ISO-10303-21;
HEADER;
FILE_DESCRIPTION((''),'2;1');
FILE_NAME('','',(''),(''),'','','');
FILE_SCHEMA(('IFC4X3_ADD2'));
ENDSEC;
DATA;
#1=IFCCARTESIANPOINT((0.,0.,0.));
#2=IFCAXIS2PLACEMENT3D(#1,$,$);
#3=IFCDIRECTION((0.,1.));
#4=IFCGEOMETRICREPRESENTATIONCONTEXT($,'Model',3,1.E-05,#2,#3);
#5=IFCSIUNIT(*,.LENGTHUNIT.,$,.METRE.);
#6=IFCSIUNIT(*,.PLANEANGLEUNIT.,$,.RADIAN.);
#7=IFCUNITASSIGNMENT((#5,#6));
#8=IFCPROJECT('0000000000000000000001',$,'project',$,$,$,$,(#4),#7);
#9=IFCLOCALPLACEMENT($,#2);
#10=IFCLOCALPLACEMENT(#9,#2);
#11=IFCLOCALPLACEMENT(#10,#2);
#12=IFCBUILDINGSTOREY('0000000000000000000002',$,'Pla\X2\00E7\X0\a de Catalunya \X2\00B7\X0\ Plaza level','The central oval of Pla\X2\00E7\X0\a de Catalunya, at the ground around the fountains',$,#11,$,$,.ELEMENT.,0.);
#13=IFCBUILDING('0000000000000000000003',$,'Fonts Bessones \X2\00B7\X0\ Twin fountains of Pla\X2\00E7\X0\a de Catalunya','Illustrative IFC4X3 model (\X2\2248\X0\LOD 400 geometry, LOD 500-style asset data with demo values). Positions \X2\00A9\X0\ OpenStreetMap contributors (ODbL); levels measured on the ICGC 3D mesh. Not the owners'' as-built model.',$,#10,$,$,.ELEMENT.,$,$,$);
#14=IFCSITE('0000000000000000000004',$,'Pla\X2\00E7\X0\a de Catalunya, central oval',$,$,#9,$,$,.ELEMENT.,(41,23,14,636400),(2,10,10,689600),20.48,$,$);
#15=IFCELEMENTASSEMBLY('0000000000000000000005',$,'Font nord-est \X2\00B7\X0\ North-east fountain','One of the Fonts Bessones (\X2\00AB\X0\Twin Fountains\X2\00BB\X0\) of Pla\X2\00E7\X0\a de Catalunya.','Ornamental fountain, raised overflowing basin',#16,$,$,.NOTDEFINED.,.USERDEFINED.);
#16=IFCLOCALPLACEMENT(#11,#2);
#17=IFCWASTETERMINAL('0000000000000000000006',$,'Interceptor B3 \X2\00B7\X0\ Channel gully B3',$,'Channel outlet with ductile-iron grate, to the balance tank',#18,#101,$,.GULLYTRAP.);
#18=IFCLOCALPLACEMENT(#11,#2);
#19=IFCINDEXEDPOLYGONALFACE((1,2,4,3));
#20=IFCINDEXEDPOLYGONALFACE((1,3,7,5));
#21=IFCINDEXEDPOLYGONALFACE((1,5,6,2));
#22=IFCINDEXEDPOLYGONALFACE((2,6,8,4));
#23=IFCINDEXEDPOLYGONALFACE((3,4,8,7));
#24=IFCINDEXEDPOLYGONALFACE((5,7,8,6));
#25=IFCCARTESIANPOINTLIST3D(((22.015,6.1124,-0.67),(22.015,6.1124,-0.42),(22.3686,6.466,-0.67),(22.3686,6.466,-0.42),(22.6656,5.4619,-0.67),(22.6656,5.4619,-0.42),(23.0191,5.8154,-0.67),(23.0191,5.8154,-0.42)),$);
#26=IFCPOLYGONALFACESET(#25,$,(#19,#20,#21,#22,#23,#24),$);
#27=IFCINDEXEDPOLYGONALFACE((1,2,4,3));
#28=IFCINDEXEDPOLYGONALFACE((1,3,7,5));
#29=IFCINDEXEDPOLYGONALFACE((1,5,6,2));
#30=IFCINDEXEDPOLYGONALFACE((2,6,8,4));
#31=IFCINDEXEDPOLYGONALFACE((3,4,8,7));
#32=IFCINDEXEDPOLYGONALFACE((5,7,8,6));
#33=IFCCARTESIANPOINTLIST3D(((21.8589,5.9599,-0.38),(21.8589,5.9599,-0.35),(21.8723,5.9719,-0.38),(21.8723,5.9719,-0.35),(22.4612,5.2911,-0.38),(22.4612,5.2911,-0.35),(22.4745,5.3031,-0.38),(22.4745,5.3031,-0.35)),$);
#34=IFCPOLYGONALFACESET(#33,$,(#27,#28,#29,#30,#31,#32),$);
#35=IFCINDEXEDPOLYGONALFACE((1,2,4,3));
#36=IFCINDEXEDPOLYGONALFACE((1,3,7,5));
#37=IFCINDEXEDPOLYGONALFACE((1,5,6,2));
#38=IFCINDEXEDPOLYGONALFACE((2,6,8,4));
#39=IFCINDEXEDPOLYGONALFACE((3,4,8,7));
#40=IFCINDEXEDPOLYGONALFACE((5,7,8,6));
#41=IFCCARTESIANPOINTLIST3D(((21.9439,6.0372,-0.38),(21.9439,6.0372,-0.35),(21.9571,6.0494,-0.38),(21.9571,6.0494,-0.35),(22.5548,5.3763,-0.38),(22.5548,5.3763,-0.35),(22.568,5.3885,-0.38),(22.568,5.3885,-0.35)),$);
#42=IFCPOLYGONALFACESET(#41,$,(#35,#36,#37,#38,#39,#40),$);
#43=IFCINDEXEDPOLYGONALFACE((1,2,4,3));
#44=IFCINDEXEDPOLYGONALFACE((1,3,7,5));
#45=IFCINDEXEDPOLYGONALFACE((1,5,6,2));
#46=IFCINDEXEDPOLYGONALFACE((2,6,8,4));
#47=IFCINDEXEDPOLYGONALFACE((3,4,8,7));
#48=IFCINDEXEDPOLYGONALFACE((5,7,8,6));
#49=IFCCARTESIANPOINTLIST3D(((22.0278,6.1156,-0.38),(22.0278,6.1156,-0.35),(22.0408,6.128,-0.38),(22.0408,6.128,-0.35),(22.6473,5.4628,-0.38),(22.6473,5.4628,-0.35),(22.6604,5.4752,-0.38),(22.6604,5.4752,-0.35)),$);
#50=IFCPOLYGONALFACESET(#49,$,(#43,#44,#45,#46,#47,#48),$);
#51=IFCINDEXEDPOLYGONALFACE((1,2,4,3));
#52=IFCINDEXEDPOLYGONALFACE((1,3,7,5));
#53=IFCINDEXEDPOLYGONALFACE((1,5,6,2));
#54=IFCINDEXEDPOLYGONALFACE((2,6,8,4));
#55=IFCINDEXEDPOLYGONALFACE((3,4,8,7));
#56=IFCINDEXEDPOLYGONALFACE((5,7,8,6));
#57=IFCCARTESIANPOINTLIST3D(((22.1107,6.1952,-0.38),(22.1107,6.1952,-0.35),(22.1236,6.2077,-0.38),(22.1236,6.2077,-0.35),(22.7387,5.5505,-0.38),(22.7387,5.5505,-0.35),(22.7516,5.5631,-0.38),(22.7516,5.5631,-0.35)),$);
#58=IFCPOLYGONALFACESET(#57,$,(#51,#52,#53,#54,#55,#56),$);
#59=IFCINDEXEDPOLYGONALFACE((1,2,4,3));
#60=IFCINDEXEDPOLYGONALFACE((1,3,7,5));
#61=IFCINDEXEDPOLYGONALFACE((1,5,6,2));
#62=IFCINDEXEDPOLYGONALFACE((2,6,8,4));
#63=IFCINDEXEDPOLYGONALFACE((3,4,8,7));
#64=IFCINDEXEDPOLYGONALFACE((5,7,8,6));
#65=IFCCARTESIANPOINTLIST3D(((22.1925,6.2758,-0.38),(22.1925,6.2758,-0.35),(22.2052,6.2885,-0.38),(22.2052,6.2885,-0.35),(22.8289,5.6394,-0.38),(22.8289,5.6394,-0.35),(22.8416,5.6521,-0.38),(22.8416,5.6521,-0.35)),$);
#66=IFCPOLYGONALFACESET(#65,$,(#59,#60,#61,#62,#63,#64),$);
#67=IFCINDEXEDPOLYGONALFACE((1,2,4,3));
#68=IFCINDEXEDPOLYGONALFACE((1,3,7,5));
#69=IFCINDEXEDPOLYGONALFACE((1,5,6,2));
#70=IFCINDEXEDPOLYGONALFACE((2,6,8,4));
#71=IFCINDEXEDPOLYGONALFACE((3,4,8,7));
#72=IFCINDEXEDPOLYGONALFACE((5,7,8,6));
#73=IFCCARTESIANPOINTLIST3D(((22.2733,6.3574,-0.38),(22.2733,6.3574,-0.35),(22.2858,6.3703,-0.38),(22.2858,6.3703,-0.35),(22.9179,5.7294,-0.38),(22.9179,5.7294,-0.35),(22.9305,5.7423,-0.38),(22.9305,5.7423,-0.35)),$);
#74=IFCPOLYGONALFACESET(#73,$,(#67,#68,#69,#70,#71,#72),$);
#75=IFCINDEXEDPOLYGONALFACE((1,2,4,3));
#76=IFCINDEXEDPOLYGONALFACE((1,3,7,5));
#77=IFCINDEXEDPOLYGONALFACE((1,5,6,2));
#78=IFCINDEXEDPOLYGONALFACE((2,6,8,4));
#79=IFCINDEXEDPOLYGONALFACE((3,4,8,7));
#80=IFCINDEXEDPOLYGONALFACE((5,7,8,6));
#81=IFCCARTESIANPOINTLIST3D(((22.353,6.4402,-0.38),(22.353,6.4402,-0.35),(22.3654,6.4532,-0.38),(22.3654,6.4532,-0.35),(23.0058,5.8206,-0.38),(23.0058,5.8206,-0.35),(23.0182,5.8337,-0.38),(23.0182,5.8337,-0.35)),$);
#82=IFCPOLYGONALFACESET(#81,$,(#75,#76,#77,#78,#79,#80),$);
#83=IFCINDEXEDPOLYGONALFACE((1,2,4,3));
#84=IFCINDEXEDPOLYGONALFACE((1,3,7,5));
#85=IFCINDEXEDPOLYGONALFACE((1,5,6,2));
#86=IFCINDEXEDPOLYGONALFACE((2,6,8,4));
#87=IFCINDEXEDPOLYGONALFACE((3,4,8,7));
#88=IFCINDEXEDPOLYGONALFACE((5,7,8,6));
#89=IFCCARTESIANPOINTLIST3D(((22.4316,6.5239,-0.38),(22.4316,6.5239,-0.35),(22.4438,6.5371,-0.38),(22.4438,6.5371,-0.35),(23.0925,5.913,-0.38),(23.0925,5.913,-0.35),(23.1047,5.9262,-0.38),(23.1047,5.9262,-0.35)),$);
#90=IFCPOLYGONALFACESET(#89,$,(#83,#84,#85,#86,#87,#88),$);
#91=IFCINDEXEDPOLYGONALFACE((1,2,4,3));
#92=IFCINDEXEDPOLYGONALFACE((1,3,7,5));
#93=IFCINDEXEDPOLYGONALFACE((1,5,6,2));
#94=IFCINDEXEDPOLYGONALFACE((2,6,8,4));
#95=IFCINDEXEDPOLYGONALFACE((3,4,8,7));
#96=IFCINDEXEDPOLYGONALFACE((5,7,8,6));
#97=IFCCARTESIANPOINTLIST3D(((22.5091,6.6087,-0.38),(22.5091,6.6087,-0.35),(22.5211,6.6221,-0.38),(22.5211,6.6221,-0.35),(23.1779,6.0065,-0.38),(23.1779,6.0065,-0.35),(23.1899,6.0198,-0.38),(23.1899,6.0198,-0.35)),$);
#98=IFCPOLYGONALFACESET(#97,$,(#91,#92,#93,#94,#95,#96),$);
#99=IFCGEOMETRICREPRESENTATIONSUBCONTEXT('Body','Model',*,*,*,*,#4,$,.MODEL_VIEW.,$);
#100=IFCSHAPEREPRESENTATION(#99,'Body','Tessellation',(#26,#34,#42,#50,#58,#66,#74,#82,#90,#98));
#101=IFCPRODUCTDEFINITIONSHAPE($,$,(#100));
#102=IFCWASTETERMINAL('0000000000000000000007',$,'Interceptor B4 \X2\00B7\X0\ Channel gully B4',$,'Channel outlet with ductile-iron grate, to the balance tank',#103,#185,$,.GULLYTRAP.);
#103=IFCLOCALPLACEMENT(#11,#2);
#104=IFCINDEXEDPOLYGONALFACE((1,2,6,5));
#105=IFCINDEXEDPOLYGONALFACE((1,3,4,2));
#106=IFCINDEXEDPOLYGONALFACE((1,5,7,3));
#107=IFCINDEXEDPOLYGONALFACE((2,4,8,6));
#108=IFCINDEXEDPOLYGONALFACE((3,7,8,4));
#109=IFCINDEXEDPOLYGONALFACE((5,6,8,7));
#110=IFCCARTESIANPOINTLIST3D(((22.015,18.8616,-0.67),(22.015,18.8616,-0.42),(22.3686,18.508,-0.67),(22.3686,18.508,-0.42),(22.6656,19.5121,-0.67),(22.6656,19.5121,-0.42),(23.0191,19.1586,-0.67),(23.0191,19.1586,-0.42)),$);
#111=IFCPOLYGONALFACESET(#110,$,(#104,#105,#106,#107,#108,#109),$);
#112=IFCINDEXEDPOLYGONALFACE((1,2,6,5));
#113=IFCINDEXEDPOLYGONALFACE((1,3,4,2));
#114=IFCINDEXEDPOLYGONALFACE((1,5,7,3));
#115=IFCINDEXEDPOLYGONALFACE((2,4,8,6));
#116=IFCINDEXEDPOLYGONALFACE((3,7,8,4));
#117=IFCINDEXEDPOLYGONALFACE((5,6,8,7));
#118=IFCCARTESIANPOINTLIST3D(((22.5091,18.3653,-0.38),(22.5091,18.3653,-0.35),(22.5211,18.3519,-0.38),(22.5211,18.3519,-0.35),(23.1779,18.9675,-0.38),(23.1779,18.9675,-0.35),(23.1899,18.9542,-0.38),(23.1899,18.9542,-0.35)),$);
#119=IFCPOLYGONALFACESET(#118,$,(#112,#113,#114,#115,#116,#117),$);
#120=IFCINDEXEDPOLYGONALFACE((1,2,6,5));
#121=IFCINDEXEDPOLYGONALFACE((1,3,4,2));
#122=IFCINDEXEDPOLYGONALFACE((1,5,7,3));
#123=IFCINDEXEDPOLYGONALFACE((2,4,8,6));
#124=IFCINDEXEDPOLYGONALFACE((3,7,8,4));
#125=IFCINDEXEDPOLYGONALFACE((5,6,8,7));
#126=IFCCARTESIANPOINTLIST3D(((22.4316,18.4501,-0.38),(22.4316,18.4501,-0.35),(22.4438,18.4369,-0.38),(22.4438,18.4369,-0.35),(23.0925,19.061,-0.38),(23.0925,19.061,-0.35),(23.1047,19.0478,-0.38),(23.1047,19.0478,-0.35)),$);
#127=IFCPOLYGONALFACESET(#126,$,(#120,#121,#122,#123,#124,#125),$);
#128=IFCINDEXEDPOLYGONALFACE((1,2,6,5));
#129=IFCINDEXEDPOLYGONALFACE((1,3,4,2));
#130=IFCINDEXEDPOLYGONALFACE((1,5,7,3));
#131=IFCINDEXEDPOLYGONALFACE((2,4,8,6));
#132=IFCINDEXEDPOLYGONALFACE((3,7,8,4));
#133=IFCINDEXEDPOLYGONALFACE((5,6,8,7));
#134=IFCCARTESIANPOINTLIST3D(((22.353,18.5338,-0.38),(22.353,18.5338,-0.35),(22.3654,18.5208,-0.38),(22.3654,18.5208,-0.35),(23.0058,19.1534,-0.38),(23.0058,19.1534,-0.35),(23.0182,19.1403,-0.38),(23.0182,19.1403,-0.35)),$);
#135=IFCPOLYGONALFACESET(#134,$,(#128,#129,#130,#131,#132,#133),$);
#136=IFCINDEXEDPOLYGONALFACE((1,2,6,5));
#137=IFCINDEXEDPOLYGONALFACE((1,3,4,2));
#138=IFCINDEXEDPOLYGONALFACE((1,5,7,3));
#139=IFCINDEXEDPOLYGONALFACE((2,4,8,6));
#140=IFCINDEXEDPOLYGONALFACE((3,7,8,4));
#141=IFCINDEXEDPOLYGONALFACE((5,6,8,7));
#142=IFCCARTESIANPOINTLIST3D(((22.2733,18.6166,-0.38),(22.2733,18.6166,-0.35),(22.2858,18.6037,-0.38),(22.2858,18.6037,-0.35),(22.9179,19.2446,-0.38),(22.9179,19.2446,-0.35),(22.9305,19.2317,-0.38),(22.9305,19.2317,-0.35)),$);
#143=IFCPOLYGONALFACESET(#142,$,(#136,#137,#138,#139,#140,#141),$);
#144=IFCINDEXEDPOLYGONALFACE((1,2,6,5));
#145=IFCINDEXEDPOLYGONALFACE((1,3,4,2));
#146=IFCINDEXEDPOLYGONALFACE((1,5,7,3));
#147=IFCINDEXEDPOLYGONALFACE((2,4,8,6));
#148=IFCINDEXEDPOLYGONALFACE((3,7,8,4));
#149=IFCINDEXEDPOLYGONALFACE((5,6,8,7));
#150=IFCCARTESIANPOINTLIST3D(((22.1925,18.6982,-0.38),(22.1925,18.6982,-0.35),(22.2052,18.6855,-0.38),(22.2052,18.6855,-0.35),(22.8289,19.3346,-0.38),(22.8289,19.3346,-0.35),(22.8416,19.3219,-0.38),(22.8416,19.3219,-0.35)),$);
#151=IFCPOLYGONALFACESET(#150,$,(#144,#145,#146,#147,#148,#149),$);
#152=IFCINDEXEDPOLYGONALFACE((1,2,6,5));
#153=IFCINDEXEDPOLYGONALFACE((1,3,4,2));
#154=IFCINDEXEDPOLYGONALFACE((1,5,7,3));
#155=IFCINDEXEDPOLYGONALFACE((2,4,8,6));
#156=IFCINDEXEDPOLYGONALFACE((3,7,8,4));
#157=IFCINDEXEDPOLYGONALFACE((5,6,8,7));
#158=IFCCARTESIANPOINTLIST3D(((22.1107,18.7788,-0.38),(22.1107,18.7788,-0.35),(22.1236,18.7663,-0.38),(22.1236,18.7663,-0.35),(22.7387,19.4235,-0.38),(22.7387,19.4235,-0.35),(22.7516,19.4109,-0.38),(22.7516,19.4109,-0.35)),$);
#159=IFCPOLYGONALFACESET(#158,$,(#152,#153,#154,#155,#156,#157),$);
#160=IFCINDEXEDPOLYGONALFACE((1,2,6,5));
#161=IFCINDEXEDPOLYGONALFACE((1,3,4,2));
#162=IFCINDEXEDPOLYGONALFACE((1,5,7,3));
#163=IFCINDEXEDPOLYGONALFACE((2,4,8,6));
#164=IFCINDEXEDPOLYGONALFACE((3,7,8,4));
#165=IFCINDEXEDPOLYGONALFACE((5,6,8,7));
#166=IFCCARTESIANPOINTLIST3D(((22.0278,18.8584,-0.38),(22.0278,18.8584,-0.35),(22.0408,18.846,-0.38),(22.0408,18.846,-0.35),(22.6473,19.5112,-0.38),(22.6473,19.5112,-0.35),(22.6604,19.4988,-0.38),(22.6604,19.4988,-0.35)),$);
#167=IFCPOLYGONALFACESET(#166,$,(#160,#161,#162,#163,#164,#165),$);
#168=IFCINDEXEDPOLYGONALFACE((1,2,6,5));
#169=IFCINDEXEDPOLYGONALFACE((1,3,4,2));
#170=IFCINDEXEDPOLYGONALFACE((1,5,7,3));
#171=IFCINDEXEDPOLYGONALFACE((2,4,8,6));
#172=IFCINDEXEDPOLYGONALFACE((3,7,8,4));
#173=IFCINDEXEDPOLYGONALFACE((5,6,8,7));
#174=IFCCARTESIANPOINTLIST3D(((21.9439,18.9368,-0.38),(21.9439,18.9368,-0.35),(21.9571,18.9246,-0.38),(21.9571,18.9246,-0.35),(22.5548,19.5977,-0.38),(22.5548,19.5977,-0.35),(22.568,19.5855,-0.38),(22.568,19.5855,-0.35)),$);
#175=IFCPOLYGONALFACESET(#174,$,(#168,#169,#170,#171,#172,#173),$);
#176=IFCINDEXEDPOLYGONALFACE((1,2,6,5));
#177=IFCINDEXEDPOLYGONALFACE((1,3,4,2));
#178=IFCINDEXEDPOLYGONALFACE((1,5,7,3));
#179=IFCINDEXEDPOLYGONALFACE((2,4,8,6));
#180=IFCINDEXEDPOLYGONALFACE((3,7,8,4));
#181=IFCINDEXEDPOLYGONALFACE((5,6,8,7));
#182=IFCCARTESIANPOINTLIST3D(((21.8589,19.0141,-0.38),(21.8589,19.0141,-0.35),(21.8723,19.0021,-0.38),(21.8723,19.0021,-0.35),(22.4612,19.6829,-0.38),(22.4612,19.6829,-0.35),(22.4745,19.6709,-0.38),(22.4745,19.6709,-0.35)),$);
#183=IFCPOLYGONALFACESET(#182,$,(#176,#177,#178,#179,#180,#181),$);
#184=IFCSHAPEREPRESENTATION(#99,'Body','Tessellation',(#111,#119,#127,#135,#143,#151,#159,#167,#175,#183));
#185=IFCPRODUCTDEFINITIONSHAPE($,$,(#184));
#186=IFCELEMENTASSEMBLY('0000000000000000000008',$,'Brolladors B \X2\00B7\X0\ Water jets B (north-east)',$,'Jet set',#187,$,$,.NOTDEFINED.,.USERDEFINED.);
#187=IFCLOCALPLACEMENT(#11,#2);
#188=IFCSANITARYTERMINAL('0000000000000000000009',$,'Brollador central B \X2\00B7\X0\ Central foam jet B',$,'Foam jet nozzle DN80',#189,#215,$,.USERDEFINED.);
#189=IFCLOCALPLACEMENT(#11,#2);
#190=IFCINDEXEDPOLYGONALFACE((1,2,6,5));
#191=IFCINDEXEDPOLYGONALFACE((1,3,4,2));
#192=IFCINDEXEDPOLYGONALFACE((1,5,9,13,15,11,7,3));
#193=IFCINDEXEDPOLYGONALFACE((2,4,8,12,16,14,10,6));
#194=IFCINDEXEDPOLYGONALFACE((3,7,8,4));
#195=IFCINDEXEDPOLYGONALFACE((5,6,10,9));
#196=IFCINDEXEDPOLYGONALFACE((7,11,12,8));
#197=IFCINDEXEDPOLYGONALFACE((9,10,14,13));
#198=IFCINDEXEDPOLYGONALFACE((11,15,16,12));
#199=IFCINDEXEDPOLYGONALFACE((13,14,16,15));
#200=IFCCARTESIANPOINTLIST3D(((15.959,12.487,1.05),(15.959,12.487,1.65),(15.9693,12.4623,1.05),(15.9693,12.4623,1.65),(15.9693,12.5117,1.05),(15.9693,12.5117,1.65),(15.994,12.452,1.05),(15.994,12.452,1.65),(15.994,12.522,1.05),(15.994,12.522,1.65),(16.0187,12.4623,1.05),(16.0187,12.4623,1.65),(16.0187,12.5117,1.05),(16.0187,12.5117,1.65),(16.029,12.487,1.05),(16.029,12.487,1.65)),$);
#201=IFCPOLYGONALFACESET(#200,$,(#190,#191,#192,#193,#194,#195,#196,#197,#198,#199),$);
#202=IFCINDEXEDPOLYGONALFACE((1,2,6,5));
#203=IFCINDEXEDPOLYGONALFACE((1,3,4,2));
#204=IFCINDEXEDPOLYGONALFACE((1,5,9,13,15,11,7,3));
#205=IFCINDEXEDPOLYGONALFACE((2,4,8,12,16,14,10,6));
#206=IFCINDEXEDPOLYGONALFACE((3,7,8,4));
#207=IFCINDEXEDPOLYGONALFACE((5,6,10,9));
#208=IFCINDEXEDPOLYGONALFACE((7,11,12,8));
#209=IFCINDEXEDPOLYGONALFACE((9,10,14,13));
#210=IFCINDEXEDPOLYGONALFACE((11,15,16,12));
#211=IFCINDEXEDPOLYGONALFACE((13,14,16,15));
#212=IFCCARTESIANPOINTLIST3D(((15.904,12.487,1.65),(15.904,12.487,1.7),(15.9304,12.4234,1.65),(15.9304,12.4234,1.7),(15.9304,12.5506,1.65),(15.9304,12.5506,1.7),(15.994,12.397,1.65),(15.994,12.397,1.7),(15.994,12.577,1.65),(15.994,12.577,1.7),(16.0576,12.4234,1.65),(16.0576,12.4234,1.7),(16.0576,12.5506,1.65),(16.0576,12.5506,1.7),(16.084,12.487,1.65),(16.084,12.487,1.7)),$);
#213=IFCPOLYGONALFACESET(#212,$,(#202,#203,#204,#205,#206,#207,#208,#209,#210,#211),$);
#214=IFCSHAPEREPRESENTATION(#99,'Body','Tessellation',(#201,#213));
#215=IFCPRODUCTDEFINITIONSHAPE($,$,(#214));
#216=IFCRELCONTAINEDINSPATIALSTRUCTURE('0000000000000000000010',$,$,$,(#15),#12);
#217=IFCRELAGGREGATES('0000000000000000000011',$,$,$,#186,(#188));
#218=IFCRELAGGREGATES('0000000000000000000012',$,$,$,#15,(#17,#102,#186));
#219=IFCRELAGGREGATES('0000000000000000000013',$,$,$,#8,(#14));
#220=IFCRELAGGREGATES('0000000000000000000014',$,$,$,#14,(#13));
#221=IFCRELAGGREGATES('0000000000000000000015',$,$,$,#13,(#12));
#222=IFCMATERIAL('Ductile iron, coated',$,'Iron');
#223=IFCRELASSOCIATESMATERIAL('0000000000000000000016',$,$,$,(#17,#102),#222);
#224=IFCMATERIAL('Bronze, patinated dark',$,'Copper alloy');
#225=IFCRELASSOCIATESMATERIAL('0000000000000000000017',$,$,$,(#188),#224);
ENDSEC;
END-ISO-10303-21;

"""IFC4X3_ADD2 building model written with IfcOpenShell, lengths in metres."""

from ifc_helpers import new_model, si_unit, direction, frame, frame_2d, origin, place, context, subcontext, project, spatial, polyline, rectangle, outline, extrude, material, element, aggregate, save


model = new_model("IFC4X3_ADD2")

# Units and contexts
model_context = context("Model", 3, precision=1e-05, world=origin(), true_north=direction((0.0, 1.0)))
body_context = subcontext(model_context, "Body", "Model", "MODEL_VIEW")
ifc_project = project(units=[si_unit("LENGTHUNIT", "METRE"), si_unit("PLANEANGLEUNIT", "RADIAN")], contexts=[model_context])

# Site, building, storey
site_placement = place(None, origin())
site = spatial("IfcSite", under=ifc_project, at=site_placement, Name="Plaça de Catalunya, central oval", CompositionType="ELEMENT", RefLatitude=(41, 23, 14, 636400), RefLongitude=(2, 10, 10, 689600), RefElevation=20.48)
building_placement = place(site_placement, origin())
building = spatial("IfcBuilding", under=site, at=building_placement, Name="Fonts Bessones · Twin fountains of Plaça de Catalunya", Description="Illustrative IFC4X3 model (≈LOD 400 geometry, LOD 500-style asset data with demo values). Positions © OpenStreetMap contributors (ODbL); levels measured on the ICGC 3D mesh. Not the owners' as-built model.", CompositionType="ELEMENT")
storey_placement = place(building_placement, origin())
storey = spatial("IfcBuildingStorey", under=building, at=storey_placement, Name="Plaça de Catalunya · Plaza level", Description="The central oval of Plaça de Catalunya, at the ground around the fountains", CompositionType="ELEMENT", Elevation=0.0)

# Element assemblies, waste terminals, sanitary terminal
assembly_1_placement = place(building_placement, origin())
assembly_1 = element("IfcElementAssembly", 1, at=assembly_1_placement, inside=storey, Name="Font nord-est · North-east fountain", Description="One of the Fonts Bessones («Twin Fountains») of Plaça de Catalunya.", ObjectType="Ornamental fountain, raised overflowing basin", AssemblyPlace="NOTDEFINED", PredefinedType="USERDEFINED")
ifc_material_1 = material(Name="Ductile iron, coated", Category="Iron")
waste_terminal_1_placement = place(building_placement, origin())
waste_terminal_1 = element("IfcWasteTerminal", 2, at=waste_terminal_1_placement, material=ifc_material_1, Name="Interceptor B3 · Channel gully B3", ObjectType="Channel outlet with ductile-iron grate, to the balance tank", PredefinedType="GULLYTRAP", context=body_context, shape_type="SweptSolid", body=[
    extrude(rectangle(XDim=0.92, YDim=0.5, at=frame_2d((0.0, 0.0), x_axis=(0.707107, -0.707107))), frame((22.5171, 5.9639, -0.67)), (0.0, 0.0, 1.0), 0.25),
    extrude(rectangle(XDim=0.9, YDim=0.018, at=frame_2d((0.0, 0.0), x_axis=(0.669131, -0.743145))), frame((22.1667, 5.6315, -0.38)), (0.0, 0.0, 1.0), 0.03),
    extrude(rectangle(XDim=0.9, YDim=0.018, at=frame_2d((0.0, 0.0), x_axis=(0.678801, -0.734323))), frame((22.2559, 5.7129, -0.38)), (0.0, 0.0, 1.0), 0.03),
    extrude(rectangle(XDim=0.9, YDim=0.018, at=frame_2d((0.0, 0.0), x_axis=(0.688355, -0.725374))), frame((22.3441, 5.7954, -0.38)), (0.0, 0.0, 1.0), 0.03),
    extrude(rectangle(XDim=0.9, YDim=0.018, at=frame_2d((0.0, 0.0), x_axis=(0.69779, -0.716302))), frame((22.4311, 5.8791, -0.38)), (0.0, 0.0, 1.0), 0.03),
    extrude(rectangle(XDim=0.9, YDim=0.018, at=frame_2d((0.0, 0.0), x_axis=(0.707107, -0.707107))), frame((22.5171, 5.9639, -0.38)), (0.0, 0.0, 1.0), 0.03),
    extrude(rectangle(XDim=0.9, YDim=0.018, at=frame_2d((0.0, 0.0), x_axis=(0.716302, -0.69779))), frame((22.6019, 6.0499, -0.38)), (0.0, 0.0, 1.0), 0.03),
    extrude(rectangle(XDim=0.9, YDim=0.018, at=frame_2d((0.0, 0.0), x_axis=(0.725374, -0.688355))), frame((22.6856, 6.1369, -0.38)), (0.0, 0.0, 1.0), 0.03),
    extrude(rectangle(XDim=0.9, YDim=0.018, at=frame_2d((0.0, 0.0), x_axis=(0.734323, -0.678801))), frame((22.7681, 6.2251, -0.38)), (0.0, 0.0, 1.0), 0.03),
    extrude(rectangle(XDim=0.9, YDim=0.018, at=frame_2d((0.0, 0.0), x_axis=(0.743145, -0.669131))), frame((22.8495, 6.3143, -0.38)), (0.0, 0.0, 1.0), 0.03),
])
waste_terminal_2_placement = place(building_placement, origin())
waste_terminal_2 = element("IfcWasteTerminal", 3, at=waste_terminal_2_placement, material=ifc_material_1, Name="Interceptor B4 · Channel gully B4", ObjectType="Channel outlet with ductile-iron grate, to the balance tank", PredefinedType="GULLYTRAP", context=body_context, shape_type="SweptSolid", body=[
    extrude(rectangle(XDim=0.92, YDim=0.5, at=frame_2d((0.0, 0.0), x_axis=(0.707107, 0.707107))), frame((22.5171, 19.0101, -0.67)), (0.0, 0.0, 1.0), 0.25),
    extrude(rectangle(XDim=0.9, YDim=0.018, at=frame_2d((0.0, 0.0), x_axis=(0.743145, 0.669131))), frame((22.8495, 18.6597, -0.38)), (0.0, 0.0, 1.0), 0.03),
    extrude(rectangle(XDim=0.9, YDim=0.018, at=frame_2d((0.0, 0.0), x_axis=(0.734323, 0.678801))), frame((22.7681, 18.7489, -0.38)), (0.0, 0.0, 1.0), 0.03),
    extrude(rectangle(XDim=0.9, YDim=0.018, at=frame_2d((0.0, 0.0), x_axis=(0.725374, 0.688355))), frame((22.6856, 18.8371, -0.38)), (0.0, 0.0, 1.0), 0.03),
    extrude(rectangle(XDim=0.9, YDim=0.018, at=frame_2d((0.0, 0.0), x_axis=(0.716302, 0.69779))), frame((22.6019, 18.9241, -0.38)), (0.0, 0.0, 1.0), 0.03),
    extrude(rectangle(XDim=0.9, YDim=0.018, at=frame_2d((0.0, 0.0), x_axis=(0.707107, 0.707107))), frame((22.5171, 19.0101, -0.38)), (0.0, 0.0, 1.0), 0.03),
    extrude(rectangle(XDim=0.9, YDim=0.018, at=frame_2d((0.0, 0.0), x_axis=(0.69779, 0.716302))), frame((22.4311, 19.0949, -0.38)), (0.0, 0.0, 1.0), 0.03),
    extrude(rectangle(XDim=0.9, YDim=0.018, at=frame_2d((0.0, 0.0), x_axis=(0.688355, 0.725374))), frame((22.3441, 19.1786, -0.38)), (0.0, 0.0, 1.0), 0.03),
    extrude(rectangle(XDim=0.9, YDim=0.018, at=frame_2d((0.0, 0.0), x_axis=(0.678801, 0.734323))), frame((22.2559, 19.2611, -0.38)), (0.0, 0.0, 1.0), 0.03),
    extrude(rectangle(XDim=0.9, YDim=0.018, at=frame_2d((0.0, 0.0), x_axis=(0.669131, 0.743145))), frame((22.1667, 19.3425, -0.38)), (0.0, 0.0, 1.0), 0.03),
])
assembly_2_placement = place(building_placement, origin())
assembly_2 = element("IfcElementAssembly", 4, at=assembly_2_placement, Name="Brolladors B · Water jets B (north-east)", ObjectType="Jet set", AssemblyPlace="NOTDEFINED", PredefinedType="USERDEFINED")
ifc_material_2 = material(Name="Bronze, patinated dark", Category="Copper alloy")
sanitary_terminal_1_placement = place(building_placement, origin())
sanitary_terminal_1 = element("IfcSanitaryTerminal", 5, at=sanitary_terminal_1_placement, material=ifc_material_2, Name="Brollador central B · Central foam jet B", ObjectType="Foam jet nozzle DN80", PredefinedType="USERDEFINED", context=body_context, shape_type="SweptSolid", body=[
    extrude(outline(polyline([(16.029, 12.487), (16.0187, 12.5117), (15.994, 12.522), (15.9693, 12.5117), (15.959, 12.487), (15.9693, 12.4623), (15.994, 12.452), (16.0187, 12.4623), (16.029, 12.487)])), frame((0.0, 0.0, 1.05)), (0.0, 0.0, 1.0), 0.6),
    extrude(outline(polyline([(16.084, 12.487), (16.0576, 12.5506), (15.994, 12.577), (15.9304, 12.5506), (15.904, 12.487), (15.9304, 12.4234), (15.994, 12.397), (16.0576, 12.4234), (16.084, 12.487)])), frame((0.0, 0.0, 1.65)), (0.0, 0.0, 1.0), 0.05),
])
aggregate(assembly_2, [sanitary_terminal_1])
aggregate(assembly_1, [waste_terminal_1, waste_terminal_2, assembly_2])

save(model, "model.ifc")
